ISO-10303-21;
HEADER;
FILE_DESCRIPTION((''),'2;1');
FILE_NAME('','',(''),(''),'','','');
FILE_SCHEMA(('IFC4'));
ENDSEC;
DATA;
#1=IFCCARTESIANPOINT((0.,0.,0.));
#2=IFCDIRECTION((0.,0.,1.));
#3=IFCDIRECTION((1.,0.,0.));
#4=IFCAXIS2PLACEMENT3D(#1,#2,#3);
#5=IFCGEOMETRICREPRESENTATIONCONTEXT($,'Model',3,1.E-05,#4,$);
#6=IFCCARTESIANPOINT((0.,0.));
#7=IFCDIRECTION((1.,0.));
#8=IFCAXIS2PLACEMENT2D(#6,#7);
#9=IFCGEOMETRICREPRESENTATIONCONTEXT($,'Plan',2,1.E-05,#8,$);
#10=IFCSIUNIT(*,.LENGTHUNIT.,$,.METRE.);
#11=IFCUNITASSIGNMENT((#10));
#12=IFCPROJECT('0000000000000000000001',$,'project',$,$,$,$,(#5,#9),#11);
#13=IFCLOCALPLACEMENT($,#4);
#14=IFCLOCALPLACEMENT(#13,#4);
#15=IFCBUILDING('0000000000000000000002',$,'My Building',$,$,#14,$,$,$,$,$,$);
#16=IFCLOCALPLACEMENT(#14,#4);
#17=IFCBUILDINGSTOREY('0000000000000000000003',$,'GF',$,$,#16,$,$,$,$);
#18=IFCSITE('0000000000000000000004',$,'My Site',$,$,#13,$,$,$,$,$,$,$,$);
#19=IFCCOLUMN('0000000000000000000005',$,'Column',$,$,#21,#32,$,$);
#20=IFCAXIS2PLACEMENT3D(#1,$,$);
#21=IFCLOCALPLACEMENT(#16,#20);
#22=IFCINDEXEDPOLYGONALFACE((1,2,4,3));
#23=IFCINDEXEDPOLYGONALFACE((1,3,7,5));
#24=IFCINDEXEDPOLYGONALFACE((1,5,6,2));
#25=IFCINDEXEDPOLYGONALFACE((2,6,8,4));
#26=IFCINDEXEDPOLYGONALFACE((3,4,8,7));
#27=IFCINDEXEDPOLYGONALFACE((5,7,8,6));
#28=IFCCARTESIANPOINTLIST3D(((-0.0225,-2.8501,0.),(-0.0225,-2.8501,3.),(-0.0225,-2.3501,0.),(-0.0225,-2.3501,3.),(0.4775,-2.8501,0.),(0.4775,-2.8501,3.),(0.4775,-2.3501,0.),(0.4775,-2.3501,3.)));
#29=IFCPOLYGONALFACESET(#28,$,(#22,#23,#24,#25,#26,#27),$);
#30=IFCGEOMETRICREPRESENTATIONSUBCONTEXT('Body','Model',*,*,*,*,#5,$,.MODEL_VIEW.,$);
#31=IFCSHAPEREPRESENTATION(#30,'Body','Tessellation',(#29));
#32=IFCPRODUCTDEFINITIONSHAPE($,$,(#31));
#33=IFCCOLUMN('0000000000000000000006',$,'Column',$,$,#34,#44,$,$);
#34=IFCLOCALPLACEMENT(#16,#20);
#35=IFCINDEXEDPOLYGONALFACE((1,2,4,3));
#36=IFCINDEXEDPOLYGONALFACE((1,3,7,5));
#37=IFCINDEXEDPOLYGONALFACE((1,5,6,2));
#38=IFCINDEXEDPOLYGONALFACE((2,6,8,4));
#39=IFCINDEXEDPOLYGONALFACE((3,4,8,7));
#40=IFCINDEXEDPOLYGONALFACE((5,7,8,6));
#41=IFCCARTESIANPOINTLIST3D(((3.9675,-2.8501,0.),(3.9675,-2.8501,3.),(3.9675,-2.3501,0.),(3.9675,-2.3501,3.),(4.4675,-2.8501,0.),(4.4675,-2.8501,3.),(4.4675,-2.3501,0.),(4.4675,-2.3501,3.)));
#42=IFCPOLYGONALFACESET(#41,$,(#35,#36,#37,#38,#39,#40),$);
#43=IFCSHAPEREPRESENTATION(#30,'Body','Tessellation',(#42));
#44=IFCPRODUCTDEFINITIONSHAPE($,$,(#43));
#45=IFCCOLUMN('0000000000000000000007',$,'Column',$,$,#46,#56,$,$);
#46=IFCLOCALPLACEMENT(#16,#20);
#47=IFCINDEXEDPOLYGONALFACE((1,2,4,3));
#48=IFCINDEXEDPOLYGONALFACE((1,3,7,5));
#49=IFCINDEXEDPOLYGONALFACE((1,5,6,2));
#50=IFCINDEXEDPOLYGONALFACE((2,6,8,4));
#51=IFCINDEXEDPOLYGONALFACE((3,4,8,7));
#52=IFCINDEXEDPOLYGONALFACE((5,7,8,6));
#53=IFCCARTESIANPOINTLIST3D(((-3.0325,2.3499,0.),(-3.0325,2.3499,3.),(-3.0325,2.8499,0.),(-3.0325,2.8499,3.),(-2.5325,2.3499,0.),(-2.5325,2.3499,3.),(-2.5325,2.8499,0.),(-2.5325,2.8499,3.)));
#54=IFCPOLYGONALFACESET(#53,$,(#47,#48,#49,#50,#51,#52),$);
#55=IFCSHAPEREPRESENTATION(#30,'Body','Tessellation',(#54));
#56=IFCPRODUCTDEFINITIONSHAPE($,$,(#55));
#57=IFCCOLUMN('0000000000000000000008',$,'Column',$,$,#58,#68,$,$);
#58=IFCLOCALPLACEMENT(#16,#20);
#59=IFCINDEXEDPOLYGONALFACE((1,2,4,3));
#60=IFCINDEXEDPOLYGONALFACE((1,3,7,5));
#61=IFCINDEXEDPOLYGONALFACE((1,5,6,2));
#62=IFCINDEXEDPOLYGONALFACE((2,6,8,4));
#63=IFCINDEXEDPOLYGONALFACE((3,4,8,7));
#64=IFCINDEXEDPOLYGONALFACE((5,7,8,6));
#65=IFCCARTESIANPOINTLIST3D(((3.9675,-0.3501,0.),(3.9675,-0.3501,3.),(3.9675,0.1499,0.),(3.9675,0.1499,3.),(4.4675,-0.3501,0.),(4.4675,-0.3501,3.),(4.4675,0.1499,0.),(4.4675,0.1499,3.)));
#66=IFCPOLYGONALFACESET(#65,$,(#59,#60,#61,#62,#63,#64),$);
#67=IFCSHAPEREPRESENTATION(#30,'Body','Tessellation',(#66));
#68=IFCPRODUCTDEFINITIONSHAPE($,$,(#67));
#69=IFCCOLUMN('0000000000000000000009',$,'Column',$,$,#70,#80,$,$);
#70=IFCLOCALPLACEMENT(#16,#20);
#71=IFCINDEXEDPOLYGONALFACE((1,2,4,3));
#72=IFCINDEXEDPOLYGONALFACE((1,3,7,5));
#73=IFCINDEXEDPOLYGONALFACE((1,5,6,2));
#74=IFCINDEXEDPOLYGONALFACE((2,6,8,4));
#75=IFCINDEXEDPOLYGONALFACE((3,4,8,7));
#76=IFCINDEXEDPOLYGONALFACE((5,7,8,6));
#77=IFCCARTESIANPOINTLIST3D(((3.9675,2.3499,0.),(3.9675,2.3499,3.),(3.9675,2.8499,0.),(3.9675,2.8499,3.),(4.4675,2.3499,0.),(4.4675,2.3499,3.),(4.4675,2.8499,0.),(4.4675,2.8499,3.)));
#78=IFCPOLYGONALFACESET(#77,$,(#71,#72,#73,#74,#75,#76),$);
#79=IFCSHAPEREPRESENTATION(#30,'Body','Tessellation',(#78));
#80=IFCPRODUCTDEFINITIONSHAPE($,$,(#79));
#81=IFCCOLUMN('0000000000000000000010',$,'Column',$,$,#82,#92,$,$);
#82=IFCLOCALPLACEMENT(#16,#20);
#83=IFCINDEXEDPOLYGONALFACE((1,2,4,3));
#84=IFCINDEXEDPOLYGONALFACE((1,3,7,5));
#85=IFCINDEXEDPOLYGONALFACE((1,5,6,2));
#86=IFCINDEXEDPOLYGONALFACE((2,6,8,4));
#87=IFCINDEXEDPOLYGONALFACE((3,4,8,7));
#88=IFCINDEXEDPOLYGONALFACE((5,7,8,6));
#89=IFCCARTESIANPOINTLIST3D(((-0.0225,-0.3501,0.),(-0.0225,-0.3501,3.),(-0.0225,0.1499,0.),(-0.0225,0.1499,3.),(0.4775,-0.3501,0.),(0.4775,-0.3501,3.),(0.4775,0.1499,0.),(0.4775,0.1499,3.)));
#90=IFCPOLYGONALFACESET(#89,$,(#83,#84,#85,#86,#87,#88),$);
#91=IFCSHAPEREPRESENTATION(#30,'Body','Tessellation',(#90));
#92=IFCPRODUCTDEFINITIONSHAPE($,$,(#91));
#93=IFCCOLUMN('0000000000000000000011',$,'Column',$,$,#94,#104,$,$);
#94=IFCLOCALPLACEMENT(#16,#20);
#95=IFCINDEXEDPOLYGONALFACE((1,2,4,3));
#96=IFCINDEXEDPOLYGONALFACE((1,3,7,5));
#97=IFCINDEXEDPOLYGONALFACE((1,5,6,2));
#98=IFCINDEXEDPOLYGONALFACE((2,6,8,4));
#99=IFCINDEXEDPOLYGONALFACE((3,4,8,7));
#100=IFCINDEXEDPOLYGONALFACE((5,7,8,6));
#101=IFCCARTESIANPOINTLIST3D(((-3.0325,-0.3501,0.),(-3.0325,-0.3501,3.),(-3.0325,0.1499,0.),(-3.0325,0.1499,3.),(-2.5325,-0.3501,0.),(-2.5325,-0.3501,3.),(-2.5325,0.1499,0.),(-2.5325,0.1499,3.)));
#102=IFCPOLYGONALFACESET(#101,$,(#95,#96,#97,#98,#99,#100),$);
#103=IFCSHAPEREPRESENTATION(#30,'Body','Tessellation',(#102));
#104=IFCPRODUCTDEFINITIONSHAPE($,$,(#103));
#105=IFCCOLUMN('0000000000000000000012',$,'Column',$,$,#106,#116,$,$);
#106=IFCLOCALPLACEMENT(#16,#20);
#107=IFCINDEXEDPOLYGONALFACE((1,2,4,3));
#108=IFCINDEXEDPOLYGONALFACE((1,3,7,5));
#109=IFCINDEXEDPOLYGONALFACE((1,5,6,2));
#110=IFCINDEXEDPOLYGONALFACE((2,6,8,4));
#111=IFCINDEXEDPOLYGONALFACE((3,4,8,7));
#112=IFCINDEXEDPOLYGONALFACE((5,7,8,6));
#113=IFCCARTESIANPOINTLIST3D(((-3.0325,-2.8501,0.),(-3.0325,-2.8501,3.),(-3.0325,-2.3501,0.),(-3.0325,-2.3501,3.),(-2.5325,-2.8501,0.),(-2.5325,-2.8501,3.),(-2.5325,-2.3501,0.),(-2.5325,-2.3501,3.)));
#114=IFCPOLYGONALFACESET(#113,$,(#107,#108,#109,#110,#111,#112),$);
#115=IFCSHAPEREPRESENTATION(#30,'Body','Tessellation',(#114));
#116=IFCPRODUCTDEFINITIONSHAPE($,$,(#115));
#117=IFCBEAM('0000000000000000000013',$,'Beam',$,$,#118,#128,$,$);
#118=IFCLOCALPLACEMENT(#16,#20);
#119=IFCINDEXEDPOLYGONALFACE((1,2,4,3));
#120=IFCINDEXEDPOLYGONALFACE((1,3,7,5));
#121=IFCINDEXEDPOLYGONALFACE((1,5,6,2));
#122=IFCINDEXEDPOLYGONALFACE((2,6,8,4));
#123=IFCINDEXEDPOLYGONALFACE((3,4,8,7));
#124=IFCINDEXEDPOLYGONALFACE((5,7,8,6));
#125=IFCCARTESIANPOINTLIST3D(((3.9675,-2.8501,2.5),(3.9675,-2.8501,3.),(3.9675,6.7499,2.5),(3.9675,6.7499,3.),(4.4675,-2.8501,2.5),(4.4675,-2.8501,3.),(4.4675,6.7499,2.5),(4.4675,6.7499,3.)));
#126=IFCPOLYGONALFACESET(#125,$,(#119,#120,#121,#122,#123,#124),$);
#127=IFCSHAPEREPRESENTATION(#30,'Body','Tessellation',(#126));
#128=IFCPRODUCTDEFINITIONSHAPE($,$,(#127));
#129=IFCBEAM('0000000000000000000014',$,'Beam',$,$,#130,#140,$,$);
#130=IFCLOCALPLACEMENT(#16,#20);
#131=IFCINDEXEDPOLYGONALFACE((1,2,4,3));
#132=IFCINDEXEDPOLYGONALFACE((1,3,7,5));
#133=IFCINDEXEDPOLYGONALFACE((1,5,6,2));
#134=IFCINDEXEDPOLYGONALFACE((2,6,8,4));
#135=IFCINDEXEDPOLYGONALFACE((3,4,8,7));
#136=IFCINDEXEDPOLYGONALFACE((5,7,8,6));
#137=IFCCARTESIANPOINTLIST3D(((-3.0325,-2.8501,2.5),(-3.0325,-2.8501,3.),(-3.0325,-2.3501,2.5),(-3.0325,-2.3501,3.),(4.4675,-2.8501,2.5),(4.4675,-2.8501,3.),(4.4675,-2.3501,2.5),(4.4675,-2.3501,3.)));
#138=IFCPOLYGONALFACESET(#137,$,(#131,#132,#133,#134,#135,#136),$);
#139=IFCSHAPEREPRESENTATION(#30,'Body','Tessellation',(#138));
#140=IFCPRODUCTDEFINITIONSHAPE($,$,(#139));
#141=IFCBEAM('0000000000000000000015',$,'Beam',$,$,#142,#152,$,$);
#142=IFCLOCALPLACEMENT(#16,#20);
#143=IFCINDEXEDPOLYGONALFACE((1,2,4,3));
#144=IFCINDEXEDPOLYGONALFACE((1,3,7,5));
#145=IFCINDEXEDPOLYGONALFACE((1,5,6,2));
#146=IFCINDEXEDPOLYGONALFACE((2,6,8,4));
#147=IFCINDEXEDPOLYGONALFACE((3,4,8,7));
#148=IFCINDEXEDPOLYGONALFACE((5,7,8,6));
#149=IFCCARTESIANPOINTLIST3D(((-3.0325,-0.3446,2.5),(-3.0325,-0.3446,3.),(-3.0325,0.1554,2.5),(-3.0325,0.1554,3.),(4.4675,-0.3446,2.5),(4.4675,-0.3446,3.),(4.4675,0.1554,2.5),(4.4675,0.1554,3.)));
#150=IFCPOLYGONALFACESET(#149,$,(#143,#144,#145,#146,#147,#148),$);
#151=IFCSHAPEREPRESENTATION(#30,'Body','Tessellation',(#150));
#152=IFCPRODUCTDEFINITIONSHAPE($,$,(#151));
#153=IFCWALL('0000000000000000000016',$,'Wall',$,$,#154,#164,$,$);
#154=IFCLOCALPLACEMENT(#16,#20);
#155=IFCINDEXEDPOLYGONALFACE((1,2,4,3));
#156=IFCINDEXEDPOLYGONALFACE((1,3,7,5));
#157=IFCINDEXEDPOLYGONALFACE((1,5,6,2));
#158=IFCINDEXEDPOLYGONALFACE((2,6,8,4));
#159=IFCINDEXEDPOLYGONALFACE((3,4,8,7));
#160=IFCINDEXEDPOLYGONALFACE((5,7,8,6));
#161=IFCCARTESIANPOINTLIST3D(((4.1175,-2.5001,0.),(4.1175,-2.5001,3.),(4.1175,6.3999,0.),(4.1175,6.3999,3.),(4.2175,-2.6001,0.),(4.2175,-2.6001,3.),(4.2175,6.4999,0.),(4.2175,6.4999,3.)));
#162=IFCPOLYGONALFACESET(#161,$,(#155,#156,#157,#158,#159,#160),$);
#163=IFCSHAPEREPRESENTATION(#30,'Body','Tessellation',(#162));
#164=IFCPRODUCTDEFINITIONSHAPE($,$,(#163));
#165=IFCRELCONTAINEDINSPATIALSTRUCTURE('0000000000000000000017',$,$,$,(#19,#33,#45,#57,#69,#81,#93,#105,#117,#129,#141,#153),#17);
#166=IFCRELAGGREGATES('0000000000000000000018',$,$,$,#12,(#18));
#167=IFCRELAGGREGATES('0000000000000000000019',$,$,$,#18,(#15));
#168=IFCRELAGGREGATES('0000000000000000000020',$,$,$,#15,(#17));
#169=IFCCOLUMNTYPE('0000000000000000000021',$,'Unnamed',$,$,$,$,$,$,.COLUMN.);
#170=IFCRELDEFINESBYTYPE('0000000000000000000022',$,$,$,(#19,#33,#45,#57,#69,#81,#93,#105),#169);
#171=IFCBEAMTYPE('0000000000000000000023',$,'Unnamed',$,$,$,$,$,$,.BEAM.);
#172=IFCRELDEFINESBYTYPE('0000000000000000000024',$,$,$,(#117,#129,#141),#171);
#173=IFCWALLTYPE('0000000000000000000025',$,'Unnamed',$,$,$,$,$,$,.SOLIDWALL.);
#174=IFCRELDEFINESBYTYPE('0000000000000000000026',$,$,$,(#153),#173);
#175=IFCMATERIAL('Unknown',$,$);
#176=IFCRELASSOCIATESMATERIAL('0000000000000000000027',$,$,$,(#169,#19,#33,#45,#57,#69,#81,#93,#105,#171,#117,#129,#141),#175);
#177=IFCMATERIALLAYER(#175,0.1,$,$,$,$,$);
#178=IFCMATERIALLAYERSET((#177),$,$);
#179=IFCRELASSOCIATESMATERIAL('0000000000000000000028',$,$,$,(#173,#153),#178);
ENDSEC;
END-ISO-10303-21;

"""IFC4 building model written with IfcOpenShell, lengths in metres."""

from ifc_helpers import new_model, si_unit, frame, origin_with_axes, origin_2d_with_axis, place, context, subcontext, project, spatial, line, indexed_curve, rectangle, outline, extrude, material, layer, layer_set, layer_usage, material_profile, profile_set, profile_usage, type_object, element, save


model = new_model("IFC4")

# Units and contexts
model_context = context("Model", 3, precision=1e-05, world=origin_with_axes())
plan_context = context("Plan", 2, precision=1e-05, world=origin_2d_with_axis())
body_context_1 = subcontext(model_context, "Body", "Model", "MODEL_VIEW")
ifc_project = project(units=[si_unit("LENGTHUNIT", "METRE")], contexts=[model_context, plan_context])

# Site, building, storey
site_placement = place(None, origin_with_axes())
site = spatial("IfcSite", under=ifc_project, at=site_placement, Name="My Site")
building_placement = place(site_placement, origin_with_axes())
building = spatial("IfcBuilding", under=site, at=building_placement, Name="My Building")
storey_placement = place(building_placement, origin_with_axes())
storey = spatial("IfcBuildingStorey", under=building, at=storey_placement, Name="GF")

# Columns
ifc_material = material(Name="Unknown")
ifc_material_profile_1 = material_profile(ifc_material, rectangle(XDim=0.5, YDim=0.5))
ifc_profile_set_1 = profile_set([ifc_material_profile_1])
ifc_profile_usage_1 = profile_usage(ifc_profile_set_1, cardinal=5)
column_type = type_object("IfcColumnType", Name="Unnamed", PredefinedType="COLUMN", material=ifc_profile_set_1)
column_1_placement = place(storey_placement, frame((0.2275, -2.6001, 0.0), z_axis=(0.0, 0.0, 1.0), x_axis=(1.0, 0.0, 0.0)))
element("IfcColumn", 1, at=column_1_placement, inside=storey, type_object=column_type, material=ifc_profile_usage_1, Name="Column", context=body_context_1, shape_type="SweptSolid", body=[
    extrude(rectangle(XDim=0.5, YDim=0.5), origin_with_axes(), (0.0, 0.0, 1.0), 3.0),
])
ifc_profile_usage_2 = profile_usage(ifc_profile_set_1, cardinal=5)
column_2_placement = place(storey_placement, frame((4.2175, -2.6001, 0.0), z_axis=(0.0, 0.0, 1.0), x_axis=(1.0, 0.0, 0.0)))
element("IfcColumn", 2, at=column_2_placement, inside=storey, type_object=column_type, material=ifc_profile_usage_2, Name="Column", context=body_context_1, shape_type="SweptSolid", body=[
    extrude(rectangle(XDim=0.5, YDim=0.5), origin_with_axes(), (0.0, 0.0, 1.0), 3.0),
])
ifc_profile_usage_3 = profile_usage(ifc_profile_set_1, cardinal=5)
column_3_placement = place(storey_placement, frame((-2.7825, 2.5999, 0.0), z_axis=(0.0, 0.0, 1.0), x_axis=(1.0, 0.0, 0.0)))
element("IfcColumn", 3, at=column_3_placement, inside=storey, type_object=column_type, material=ifc_profile_usage_3, Name="Column", context=body_context_1, shape_type="SweptSolid", body=[
    extrude(rectangle(XDim=0.5, YDim=0.5), origin_with_axes(), (0.0, 0.0, 1.0), 3.0),
])
ifc_profile_usage_4 = profile_usage(ifc_profile_set_1, cardinal=5)
column_4_placement = place(storey_placement, frame((4.2175, -0.1001, 0.0), z_axis=(0.0, 0.0, 1.0), x_axis=(1.0, 0.0, 0.0)))
element("IfcColumn", 4, at=column_4_placement, inside=storey, type_object=column_type, material=ifc_profile_usage_4, Name="Column", context=body_context_1, shape_type="SweptSolid", body=[
    extrude(rectangle(XDim=0.5, YDim=0.5), origin_with_axes(), (0.0, 0.0, 1.0), 3.0),
])
ifc_profile_usage_5 = profile_usage(ifc_profile_set_1, cardinal=5)
column_5_placement = place(storey_placement, frame((4.2175, 2.5999, 0.0), z_axis=(0.0, 0.0, 1.0), x_axis=(1.0, 0.0, 0.0)))
element("IfcColumn", 5, at=column_5_placement, inside=storey, type_object=column_type, material=ifc_profile_usage_5, Name="Column", context=body_context_1, shape_type="SweptSolid", body=[
    extrude(rectangle(XDim=0.5, YDim=0.5), origin_with_axes(), (0.0, 0.0, 1.0), 3.0),
])
ifc_profile_usage_6 = profile_usage(ifc_profile_set_1, cardinal=5)
column_6_placement = place(storey_placement, frame((0.2275, -0.1001, 0.0), z_axis=(0.0, 0.0, 1.0), x_axis=(1.0, 0.0, 0.0)))
element("IfcColumn", 6, at=column_6_placement, inside=storey, type_object=column_type, material=ifc_profile_usage_6, Name="Column", context=body_context_1, shape_type="SweptSolid", body=[
    extrude(rectangle(XDim=0.5, YDim=0.5), origin_with_axes(), (0.0, 0.0, 1.0), 3.0),
])
ifc_profile_usage_7 = profile_usage(ifc_profile_set_1, cardinal=5)
column_7_placement = place(storey_placement, frame((-2.7825, -0.1001, 0.0), z_axis=(0.0, 0.0, 1.0), x_axis=(1.0, 0.0, 0.0)))
element("IfcColumn", 7, at=column_7_placement, inside=storey, type_object=column_type, material=ifc_profile_usage_7, Name="Column", context=body_context_1, shape_type="SweptSolid", body=[
    extrude(rectangle(XDim=0.5, YDim=0.5), origin_with_axes(), (0.0, 0.0, 1.0), 3.0),
])
ifc_profile_usage_8 = profile_usage(ifc_profile_set_1, cardinal=5)
column_8_placement = place(storey_placement, frame((-2.7825, -2.6001, 0.0), z_axis=(0.0, 0.0, 1.0), x_axis=(1.0, 0.0, 0.0)))
element("IfcColumn", 8, at=column_8_placement, inside=storey, type_object=column_type, material=ifc_profile_usage_8, Name="Column", context=body_context_1, shape_type="SweptSolid", body=[
    extrude(rectangle(XDim=0.5, YDim=0.5), origin_with_axes(), (0.0, 0.0, 1.0), 3.0),
])

# Beams
ifc_material_profile_2 = material_profile(ifc_material, rectangle(XDim=0.5, YDim=0.5))
ifc_profile_set_2 = profile_set([ifc_material_profile_2])
ifc_profile_usage_9 = profile_usage(ifc_profile_set_2, cardinal=5)
beam_type = type_object("IfcBeamType", Name="Unnamed", PredefinedType="BEAM", material=ifc_profile_set_2)
beam_1_placement = place(storey_placement, frame((4.2175, -2.8501, 2.75), z_axis=(0.0, 1.0, 0.0), x_axis=(-1.0, 0.0, 0.0)))
element("IfcBeam", 9, at=beam_1_placement, inside=storey, type_object=beam_type, material=ifc_profile_usage_9, Name="Beam", context=body_context_1, shape_type="SweptSolid", body=[
    extrude(rectangle(XDim=0.5, YDim=0.5), origin_with_axes(), (0.0, 0.0, 1.0), 9.6),
])
ifc_profile_usage_10 = profile_usage(ifc_profile_set_2, cardinal=5)
beam_2_placement = place(storey_placement, frame((-3.0325, -2.6001, 2.75), z_axis=(1.0, -0.000001, 0.0), x_axis=(0.000001, 1.0, 0.0)))
element("IfcBeam", 10, at=beam_2_placement, inside=storey, type_object=beam_type, material=ifc_profile_usage_10, Name="Beam", context=body_context_1, shape_type="SweptSolid", body=[
    extrude(rectangle(XDim=0.5, YDim=0.5), origin_with_axes(), (0.0, 0.0, 1.0), 7.5),
])
ifc_profile_usage_11 = profile_usage(ifc_profile_set_2, cardinal=5)
beam_3_placement = place(storey_placement, frame((-3.0325, -0.0946, 2.75), z_axis=(1.0, -0.000001, 0.0), x_axis=(0.000001, 1.0, 0.0)))
element("IfcBeam", 11, at=beam_3_placement, inside=storey, type_object=beam_type, material=ifc_profile_usage_11, Name="Beam", context=body_context_1, shape_type="SweptSolid", body=[
    extrude(rectangle(XDim=0.5, YDim=0.5), origin_with_axes(), (0.0, 0.0, 1.0), 7.5),
])

# Shared definitions
ifc_layer_1 = layer(ifc_material, 0.1)
ifc_layer_set_1 = layer_set([ifc_layer_1])
wall_type = type_object("IfcWallType", Name="Unnamed", PredefinedType="SOLIDWALL", material=ifc_layer_set_1)

# Wall
ifc_layer_usage_1 = layer_usage(ifc_layer_set_1, "AXIS2", "POSITIVE", 0.0)
wall_1_placement = place(storey_placement, frame((4.2175, -2.6001, 0.0), z_axis=(0.0, 0.0, 1.0), x_axis=(0.0, 1.0, 0.0)))
element("IfcWall", 12, at=wall_1_placement, inside=storey, type_object=wall_type, material=ifc_layer_usage_1, Name="Wall", context=body_context_1, shape_type="SweptSolid", body=[
    extrude(outline(indexed_curve([(0.0, 0.0), (0.1, 0.1), (9.0, 0.1), (9.1, 0.0)], segments=[line(1, 2, 3, 4, 1)])), origin_with_axes(), (0.0, 0.0, 1.0), 3.0),
])

save(model, "model.ifc")
